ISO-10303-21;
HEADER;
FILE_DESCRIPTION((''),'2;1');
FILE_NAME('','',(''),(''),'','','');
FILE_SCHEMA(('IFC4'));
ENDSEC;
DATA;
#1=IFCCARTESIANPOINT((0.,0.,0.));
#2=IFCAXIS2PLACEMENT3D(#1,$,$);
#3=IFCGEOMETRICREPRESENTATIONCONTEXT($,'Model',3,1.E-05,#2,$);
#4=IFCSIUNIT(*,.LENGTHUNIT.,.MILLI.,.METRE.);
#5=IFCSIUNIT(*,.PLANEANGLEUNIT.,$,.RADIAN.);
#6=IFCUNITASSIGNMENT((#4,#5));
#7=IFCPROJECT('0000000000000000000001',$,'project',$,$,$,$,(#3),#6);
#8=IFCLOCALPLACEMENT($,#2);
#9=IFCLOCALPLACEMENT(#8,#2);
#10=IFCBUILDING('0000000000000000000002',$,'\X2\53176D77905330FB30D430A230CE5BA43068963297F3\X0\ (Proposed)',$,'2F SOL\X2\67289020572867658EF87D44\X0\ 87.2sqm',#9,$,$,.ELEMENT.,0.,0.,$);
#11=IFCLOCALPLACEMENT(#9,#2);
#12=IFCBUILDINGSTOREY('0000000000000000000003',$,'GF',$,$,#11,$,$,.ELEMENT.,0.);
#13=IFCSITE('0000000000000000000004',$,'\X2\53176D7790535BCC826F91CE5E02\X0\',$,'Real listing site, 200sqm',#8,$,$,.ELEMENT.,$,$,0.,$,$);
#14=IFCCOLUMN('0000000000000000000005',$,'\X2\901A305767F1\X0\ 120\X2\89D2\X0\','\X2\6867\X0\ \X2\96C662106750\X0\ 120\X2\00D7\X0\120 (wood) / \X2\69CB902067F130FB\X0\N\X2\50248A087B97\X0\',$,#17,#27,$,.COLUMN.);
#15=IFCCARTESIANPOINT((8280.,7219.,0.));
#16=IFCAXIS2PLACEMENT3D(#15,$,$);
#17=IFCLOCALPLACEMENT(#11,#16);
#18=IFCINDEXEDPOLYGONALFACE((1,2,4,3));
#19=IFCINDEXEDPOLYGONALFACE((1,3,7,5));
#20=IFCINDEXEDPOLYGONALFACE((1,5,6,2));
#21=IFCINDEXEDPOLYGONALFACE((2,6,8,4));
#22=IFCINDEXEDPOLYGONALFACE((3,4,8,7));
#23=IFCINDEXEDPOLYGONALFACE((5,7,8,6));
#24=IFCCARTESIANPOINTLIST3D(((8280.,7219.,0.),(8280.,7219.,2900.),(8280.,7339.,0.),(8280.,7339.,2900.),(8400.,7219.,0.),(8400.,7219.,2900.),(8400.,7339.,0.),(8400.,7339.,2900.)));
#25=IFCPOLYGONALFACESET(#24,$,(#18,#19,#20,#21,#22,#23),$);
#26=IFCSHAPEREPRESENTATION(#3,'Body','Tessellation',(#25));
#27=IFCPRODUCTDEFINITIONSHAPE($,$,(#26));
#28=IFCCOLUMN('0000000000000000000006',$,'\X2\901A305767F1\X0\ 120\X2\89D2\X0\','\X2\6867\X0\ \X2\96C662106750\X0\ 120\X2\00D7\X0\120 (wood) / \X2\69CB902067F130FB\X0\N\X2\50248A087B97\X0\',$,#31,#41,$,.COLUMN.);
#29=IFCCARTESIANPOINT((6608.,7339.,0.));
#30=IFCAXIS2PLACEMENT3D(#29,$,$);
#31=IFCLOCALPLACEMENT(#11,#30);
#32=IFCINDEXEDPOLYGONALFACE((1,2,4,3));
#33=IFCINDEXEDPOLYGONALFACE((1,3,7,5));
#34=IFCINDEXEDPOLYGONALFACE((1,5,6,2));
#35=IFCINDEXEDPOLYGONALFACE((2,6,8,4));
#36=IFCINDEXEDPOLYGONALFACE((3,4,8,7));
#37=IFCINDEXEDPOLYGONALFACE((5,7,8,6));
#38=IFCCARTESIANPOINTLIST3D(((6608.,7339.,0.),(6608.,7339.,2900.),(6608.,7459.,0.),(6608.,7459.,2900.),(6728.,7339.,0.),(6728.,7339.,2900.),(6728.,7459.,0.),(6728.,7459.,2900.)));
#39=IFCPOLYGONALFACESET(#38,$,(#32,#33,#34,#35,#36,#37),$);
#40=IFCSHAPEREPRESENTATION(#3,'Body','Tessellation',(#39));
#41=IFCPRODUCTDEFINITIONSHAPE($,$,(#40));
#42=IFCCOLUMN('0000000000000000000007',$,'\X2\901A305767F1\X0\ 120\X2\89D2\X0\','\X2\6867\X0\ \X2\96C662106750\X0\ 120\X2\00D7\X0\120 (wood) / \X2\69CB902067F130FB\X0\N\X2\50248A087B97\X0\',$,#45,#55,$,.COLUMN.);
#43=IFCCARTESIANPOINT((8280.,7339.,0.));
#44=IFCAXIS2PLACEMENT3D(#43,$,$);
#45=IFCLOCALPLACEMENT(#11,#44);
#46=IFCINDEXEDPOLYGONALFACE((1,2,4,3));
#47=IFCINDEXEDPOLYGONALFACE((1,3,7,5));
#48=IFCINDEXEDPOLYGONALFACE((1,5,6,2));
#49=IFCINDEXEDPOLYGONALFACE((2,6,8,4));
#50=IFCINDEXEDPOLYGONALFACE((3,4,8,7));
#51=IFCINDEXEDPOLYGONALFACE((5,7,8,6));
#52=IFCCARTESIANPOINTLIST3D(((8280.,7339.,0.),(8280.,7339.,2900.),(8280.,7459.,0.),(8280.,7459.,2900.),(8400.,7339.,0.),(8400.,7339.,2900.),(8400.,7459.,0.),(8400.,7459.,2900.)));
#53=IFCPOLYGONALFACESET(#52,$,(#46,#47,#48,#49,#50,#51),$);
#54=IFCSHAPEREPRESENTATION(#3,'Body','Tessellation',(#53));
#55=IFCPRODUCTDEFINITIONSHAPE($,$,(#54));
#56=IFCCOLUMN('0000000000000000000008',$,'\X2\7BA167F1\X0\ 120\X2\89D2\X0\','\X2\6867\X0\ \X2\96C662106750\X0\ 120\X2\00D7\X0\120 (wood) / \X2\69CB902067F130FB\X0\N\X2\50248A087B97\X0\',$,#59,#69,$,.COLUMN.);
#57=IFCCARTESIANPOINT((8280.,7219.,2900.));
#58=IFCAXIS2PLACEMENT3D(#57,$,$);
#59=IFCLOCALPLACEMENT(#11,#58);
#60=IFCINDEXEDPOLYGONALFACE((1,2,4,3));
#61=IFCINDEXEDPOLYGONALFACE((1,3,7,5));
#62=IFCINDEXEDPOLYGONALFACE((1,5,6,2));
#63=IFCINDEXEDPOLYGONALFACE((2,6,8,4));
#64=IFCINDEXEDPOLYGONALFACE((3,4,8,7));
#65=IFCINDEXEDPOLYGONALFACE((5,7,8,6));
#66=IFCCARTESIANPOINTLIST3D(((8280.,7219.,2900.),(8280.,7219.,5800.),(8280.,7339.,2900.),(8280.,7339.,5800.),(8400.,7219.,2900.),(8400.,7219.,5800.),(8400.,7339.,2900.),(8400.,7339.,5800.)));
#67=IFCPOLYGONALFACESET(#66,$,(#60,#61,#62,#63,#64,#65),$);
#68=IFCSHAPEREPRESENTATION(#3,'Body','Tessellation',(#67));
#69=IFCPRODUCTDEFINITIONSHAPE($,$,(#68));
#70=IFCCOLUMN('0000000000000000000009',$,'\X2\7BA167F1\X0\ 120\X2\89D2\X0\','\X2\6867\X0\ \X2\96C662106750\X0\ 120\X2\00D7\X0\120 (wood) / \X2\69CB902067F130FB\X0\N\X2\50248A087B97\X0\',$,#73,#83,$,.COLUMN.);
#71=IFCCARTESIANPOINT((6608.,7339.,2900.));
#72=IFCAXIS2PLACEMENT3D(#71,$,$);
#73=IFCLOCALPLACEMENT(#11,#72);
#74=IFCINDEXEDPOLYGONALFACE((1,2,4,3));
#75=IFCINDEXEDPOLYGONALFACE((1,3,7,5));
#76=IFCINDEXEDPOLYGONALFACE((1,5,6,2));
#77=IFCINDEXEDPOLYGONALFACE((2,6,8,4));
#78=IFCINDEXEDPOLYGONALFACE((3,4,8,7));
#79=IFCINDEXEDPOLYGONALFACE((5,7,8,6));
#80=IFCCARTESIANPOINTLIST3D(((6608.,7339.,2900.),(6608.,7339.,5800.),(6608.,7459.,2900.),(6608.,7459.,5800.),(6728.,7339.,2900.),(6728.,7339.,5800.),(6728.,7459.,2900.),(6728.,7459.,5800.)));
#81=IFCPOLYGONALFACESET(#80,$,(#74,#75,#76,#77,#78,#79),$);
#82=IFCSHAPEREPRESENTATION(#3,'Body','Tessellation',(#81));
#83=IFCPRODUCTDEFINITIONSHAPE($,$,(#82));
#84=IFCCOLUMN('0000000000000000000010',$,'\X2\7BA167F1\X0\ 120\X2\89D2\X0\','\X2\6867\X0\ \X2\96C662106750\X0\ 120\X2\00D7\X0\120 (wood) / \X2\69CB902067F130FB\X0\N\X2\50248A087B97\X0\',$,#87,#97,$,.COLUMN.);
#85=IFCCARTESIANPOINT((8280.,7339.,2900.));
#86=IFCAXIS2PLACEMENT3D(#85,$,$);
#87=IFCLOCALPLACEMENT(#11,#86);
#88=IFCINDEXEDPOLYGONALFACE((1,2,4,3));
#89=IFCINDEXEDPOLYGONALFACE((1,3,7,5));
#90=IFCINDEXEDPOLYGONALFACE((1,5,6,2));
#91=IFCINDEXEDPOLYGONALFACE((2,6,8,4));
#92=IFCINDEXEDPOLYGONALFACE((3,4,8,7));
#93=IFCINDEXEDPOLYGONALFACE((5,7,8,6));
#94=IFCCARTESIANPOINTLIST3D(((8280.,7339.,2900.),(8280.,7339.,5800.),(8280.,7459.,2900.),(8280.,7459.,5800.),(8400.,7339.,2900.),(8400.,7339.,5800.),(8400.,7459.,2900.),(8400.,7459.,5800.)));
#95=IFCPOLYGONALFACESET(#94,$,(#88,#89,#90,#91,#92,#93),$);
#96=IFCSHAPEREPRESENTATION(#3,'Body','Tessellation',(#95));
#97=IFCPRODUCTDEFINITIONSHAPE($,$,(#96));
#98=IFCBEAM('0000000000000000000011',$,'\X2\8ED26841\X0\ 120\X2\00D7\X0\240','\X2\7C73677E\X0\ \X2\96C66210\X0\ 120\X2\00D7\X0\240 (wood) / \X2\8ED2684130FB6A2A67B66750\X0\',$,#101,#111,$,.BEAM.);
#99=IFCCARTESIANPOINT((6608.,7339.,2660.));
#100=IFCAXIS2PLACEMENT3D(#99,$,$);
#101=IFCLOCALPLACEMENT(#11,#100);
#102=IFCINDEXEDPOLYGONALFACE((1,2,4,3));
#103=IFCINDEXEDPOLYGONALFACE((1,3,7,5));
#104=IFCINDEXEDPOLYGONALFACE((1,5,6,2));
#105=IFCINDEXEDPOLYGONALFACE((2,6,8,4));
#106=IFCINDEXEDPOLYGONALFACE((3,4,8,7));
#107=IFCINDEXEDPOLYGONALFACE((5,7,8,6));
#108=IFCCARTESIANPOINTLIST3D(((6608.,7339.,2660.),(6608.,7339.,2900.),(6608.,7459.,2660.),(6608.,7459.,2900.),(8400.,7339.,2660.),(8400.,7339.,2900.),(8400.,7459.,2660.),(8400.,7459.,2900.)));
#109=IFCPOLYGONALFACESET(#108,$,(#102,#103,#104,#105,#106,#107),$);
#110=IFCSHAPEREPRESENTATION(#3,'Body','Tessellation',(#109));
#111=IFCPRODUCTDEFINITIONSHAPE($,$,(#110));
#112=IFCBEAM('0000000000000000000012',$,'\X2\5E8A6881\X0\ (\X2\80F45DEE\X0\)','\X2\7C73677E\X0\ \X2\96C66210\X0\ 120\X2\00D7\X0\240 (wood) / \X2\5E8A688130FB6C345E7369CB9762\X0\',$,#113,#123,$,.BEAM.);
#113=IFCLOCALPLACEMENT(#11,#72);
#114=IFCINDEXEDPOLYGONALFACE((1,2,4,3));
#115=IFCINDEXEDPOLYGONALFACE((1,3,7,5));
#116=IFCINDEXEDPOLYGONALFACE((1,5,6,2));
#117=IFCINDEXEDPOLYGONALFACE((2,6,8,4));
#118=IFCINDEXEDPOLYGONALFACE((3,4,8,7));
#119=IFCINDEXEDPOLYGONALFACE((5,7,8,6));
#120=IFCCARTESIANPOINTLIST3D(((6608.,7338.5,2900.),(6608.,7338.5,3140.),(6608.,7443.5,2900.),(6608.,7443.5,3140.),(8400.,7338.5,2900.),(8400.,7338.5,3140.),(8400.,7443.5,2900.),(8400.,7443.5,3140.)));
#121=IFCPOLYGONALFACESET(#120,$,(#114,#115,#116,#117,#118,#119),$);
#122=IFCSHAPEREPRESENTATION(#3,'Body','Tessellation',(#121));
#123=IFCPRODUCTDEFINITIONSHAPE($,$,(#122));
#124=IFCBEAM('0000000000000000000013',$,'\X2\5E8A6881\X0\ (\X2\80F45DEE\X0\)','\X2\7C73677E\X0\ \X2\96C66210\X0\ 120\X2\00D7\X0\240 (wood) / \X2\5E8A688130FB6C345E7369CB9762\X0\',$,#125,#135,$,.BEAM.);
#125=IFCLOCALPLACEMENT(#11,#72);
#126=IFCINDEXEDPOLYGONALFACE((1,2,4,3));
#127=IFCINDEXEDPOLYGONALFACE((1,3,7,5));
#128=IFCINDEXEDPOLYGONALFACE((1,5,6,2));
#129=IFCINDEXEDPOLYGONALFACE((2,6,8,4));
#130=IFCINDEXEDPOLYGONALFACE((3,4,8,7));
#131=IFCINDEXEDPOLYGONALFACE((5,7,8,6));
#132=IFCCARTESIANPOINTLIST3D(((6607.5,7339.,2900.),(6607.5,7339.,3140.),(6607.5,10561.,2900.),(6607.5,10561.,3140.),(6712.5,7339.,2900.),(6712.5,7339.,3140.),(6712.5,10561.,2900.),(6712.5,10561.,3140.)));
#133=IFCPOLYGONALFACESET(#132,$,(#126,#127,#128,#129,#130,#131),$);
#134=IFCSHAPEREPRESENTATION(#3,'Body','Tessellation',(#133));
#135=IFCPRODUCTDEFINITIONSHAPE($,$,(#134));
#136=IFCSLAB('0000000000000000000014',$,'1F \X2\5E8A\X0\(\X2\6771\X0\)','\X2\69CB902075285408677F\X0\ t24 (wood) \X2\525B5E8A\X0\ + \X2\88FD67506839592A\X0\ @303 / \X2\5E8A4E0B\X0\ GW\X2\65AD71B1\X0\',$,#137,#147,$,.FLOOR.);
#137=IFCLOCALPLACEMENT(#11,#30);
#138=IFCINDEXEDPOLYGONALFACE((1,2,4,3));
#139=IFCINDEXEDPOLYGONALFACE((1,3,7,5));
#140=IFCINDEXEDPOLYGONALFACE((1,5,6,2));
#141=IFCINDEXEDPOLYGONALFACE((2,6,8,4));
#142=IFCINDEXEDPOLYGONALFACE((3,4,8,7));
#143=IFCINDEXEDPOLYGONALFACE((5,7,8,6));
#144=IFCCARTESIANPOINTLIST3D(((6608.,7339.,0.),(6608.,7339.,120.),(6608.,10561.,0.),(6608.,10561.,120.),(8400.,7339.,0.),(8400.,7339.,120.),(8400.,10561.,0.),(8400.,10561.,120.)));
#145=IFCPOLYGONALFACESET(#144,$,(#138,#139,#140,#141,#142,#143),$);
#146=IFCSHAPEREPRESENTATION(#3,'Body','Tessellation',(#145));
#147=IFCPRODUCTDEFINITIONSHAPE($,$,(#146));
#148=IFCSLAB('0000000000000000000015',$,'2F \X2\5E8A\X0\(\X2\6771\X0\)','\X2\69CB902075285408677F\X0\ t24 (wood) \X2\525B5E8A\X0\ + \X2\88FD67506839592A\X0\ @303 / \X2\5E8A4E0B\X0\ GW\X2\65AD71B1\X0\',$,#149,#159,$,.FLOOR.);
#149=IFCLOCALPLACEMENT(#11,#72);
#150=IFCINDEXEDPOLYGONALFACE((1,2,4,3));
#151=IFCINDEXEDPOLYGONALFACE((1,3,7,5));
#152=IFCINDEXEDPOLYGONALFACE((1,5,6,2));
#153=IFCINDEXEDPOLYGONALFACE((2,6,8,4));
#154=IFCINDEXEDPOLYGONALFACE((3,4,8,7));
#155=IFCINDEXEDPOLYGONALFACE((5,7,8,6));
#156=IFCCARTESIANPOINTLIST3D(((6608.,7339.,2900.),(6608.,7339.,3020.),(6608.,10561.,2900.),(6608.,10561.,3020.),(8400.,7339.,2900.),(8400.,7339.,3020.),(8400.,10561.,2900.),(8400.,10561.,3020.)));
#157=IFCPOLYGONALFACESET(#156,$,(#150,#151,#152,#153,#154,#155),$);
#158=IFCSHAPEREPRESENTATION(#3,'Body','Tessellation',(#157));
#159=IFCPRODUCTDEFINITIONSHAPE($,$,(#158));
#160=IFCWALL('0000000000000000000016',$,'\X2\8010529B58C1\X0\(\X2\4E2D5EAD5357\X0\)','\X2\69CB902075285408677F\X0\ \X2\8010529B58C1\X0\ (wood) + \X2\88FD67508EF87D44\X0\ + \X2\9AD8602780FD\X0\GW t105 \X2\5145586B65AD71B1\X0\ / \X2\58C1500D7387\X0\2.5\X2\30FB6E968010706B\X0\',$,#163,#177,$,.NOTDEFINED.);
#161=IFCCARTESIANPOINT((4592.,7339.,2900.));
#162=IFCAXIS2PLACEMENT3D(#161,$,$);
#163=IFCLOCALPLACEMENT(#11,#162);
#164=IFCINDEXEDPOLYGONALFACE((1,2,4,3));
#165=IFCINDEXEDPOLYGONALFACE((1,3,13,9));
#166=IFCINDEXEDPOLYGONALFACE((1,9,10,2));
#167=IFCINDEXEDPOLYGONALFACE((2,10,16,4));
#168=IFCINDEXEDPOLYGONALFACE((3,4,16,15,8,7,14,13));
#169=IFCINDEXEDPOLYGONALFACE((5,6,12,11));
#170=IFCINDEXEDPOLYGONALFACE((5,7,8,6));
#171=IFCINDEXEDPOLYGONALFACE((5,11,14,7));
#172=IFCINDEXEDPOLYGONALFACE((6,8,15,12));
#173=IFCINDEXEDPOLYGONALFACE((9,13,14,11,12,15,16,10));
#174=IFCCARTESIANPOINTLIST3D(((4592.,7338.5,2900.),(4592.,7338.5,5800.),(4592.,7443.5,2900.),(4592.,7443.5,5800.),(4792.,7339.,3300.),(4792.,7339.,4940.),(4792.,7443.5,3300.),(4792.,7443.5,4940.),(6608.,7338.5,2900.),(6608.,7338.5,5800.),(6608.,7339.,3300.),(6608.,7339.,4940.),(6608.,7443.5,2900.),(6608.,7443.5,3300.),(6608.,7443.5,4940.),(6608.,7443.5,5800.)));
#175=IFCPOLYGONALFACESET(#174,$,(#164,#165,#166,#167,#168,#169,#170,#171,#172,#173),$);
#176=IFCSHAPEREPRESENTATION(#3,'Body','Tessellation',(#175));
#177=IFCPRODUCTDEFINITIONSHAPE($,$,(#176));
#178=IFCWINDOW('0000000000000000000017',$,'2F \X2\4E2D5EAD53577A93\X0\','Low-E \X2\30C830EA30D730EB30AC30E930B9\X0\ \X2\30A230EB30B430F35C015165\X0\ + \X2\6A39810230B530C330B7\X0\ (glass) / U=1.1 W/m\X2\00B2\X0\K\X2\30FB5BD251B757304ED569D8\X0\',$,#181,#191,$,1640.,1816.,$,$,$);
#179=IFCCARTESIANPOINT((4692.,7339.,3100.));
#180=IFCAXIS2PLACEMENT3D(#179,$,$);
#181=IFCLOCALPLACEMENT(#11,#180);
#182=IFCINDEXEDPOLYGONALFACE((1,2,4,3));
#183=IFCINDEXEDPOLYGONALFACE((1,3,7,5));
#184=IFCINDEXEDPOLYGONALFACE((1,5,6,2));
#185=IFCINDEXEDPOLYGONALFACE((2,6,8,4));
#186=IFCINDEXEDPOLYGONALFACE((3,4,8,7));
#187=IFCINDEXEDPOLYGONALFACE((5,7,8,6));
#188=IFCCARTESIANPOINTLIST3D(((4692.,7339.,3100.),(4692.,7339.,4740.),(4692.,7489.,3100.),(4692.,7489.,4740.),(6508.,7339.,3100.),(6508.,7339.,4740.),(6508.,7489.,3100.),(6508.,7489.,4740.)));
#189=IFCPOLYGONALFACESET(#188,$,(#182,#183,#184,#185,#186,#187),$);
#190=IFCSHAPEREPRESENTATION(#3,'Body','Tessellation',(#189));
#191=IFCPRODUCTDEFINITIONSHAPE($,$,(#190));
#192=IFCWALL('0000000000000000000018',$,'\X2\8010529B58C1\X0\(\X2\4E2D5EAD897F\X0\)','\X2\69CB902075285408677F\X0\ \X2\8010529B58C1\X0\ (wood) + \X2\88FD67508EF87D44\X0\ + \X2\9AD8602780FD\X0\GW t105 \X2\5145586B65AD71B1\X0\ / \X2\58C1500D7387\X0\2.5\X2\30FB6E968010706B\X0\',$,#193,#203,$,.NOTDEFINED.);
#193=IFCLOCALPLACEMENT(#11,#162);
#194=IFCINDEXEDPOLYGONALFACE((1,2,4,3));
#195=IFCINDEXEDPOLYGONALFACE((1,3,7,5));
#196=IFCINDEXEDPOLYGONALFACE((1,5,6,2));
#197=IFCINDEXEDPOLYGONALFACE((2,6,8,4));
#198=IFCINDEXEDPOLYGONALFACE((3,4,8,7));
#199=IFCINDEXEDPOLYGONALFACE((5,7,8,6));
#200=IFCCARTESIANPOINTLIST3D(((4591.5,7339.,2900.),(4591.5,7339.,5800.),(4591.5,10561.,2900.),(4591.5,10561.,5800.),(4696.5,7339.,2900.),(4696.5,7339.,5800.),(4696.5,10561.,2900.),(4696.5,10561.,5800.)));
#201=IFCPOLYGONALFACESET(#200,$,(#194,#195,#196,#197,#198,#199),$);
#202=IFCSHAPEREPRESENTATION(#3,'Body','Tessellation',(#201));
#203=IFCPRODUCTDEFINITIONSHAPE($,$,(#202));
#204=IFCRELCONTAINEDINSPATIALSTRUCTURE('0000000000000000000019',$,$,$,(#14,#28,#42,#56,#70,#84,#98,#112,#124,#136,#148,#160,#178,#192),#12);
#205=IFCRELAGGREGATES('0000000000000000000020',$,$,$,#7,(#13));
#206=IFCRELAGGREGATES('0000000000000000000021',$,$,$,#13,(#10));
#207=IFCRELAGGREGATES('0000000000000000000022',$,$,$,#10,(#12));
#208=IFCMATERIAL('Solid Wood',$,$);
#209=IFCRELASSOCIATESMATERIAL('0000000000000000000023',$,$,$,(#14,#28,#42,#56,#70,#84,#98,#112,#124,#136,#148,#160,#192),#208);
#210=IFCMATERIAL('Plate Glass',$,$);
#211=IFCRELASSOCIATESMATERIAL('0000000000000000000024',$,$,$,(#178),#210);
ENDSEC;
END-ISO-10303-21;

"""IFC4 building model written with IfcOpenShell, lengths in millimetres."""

from ifc_helpers import new_model, si_unit, frame, frame_2d, origin, place, context, project, spatial, rectangle, extrude, material, element, fill, save


model = new_model("IFC4")

# Units and contexts
model_context = context("Model", 3, precision=1e-05, world=origin())
ifc_project = project(units=[si_unit("LENGTHUNIT", "METRE", prefix="MILLI"), si_unit("PLANEANGLEUNIT", "RADIAN")], contexts=[model_context])

# Site, building, storey
site_placement = place(None, origin())
site = spatial("IfcSite", under=ifc_project, at=site_placement, Name="北海道富良野市", ObjectType="Real listing site, 200sqm", CompositionType="ELEMENT", RefElevation=0.0)
building_placement = place(site_placement, origin())
building = spatial("IfcBuilding", under=site, at=building_placement, Name="北海道・ピアノ室と防音 (Proposed)", ObjectType="2F SOL木造在来軸組 87.2sqm", CompositionType="ELEMENT", ElevationOfRefHeight=0.0, ElevationOfTerrain=0.0)
storey_placement = place(building_placement, origin())
storey = spatial("IfcBuildingStorey", under=building, at=storey_placement, Name="GF", CompositionType="ELEMENT", Elevation=0.0)

# Columns
ifc_material_1 = material(Name="Solid Wood")
column_1_placement = place(storey_placement, frame((8280.0, 7219.0, 0.0)))
element("IfcColumn", 1, at=column_1_placement, inside=storey, material=ifc_material_1, Name="通し柱 120角", Description="桧 集成材 120×120 (wood) / 構造柱・N値計算", PredefinedType="COLUMN", context=model_context, shape_type="SweptSolid", body=[
    extrude(rectangle(XDim=120.0, YDim=120.0, at=frame_2d((60.0, 60.0))), frame((8280.0, 7219.0, 0.0)), (0.0, 0.0, 1.0), 2900.0),
])
column_2_placement = place(storey_placement, frame((6608.0, 7339.0, 0.0)))
element("IfcColumn", 2, at=column_2_placement, inside=storey, material=ifc_material_1, Name="通し柱 120角", Description="桧 集成材 120×120 (wood) / 構造柱・N値計算", PredefinedType="COLUMN", context=model_context, shape_type="SweptSolid", body=[
    extrude(rectangle(XDim=120.0, YDim=120.0, at=frame_2d((60.0, 60.0))), frame((6608.0, 7339.0, 0.0)), (0.0, 0.0, 1.0), 2900.0),
])
column_3_placement = place(storey_placement, frame((8280.0, 7339.0, 0.0)))
element("IfcColumn", 3, at=column_3_placement, inside=storey, material=ifc_material_1, Name="通し柱 120角", Description="桧 集成材 120×120 (wood) / 構造柱・N値計算", PredefinedType="COLUMN", context=model_context, shape_type="SweptSolid", body=[
    extrude(rectangle(XDim=120.0, YDim=120.0, at=frame_2d((60.0, 60.0))), frame((8280.0, 7339.0, 0.0)), (0.0, 0.0, 1.0), 2900.0),
])
column_4_placement = place(storey_placement, frame((8280.0, 7219.0, 2900.0)))
element("IfcColumn", 4, at=column_4_placement, inside=storey, material=ifc_material_1, Name="管柱 120角", Description="桧 集成材 120×120 (wood) / 構造柱・N値計算", PredefinedType="COLUMN", context=model_context, shape_type="SweptSolid", body=[
    extrude(rectangle(XDim=120.0, YDim=120.0, at=frame_2d((60.0, 60.0))), frame((8280.0, 7219.0, 2900.0)), (0.0, 0.0, 1.0), 2900.0),
])
column_5_placement = place(storey_placement, frame((6608.0, 7339.0, 2900.0)))
element("IfcColumn", 5, at=column_5_placement, inside=storey, material=ifc_material_1, Name="管柱 120角", Description="桧 集成材 120×120 (wood) / 構造柱・N値計算", PredefinedType="COLUMN", context=model_context, shape_type="SweptSolid", body=[
    extrude(rectangle(XDim=120.0, YDim=120.0, at=frame_2d((60.0, 60.0))), frame((6608.0, 7339.0, 2900.0)), (0.0, 0.0, 1.0), 2900.0),
])
column_6_placement = place(storey_placement, frame((8280.0, 7339.0, 2900.0)))
element("IfcColumn", 6, at=column_6_placement, inside=storey, material=ifc_material_1, Name="管柱 120角", Description="桧 集成材 120×120 (wood) / 構造柱・N値計算", PredefinedType="COLUMN", context=model_context, shape_type="SweptSolid", body=[
    extrude(rectangle(XDim=120.0, YDim=120.0, at=frame_2d((60.0, 60.0))), frame((8280.0, 7339.0, 2900.0)), (0.0, 0.0, 1.0), 2900.0),
])

# Beams
beam_1_placement = place(storey_placement, frame((6608.0, 7339.0, 2660.0)))
element("IfcBeam", 7, at=beam_1_placement, inside=storey, material=ifc_material_1, Name="軒桁 120×240", Description="米松 集成 120×240 (wood) / 軒桁・横架材", PredefinedType="BEAM", context=model_context, shape_type="SweptSolid", body=[
    extrude(rectangle(XDim=1792.0, YDim=120.0, at=frame_2d((896.0, 60.0))), frame((6608.0, 7339.0, 2660.0)), (0.0, 0.0, 1.0), 240.0),
])
beam_2_placement = place(storey_placement, frame((6608.0, 7339.0, 2900.0)))
element("IfcBeam", 8, at=beam_2_placement, inside=storey, material=ifc_material_1, Name="床梁 (胴差)", Description="米松 集成 120×240 (wood) / 床梁・水平構面", PredefinedType="BEAM", context=model_context, shape_type="SweptSolid", body=[
    extrude(rectangle(XDim=1792.0, YDim=105.0, at=frame_2d((896.0, 52.0))), frame((6608.0, 7339.0, 2900.0)), (0.0, 0.0, 1.0), 240.0),
])
beam_3_placement = place(storey_placement, frame((6608.0, 7339.0, 2900.0)))
element("IfcBeam", 9, at=beam_3_placement, inside=storey, material=ifc_material_1, Name="床梁 (胴差)", Description="米松 集成 120×240 (wood) / 床梁・水平構面", PredefinedType="BEAM", context=model_context, shape_type="SweptSolid", body=[
    extrude(rectangle(XDim=105.0, YDim=3222.0, at=frame_2d((52.0, 1611.0))), frame((6608.0, 7339.0, 2900.0)), (0.0, 0.0, 1.0), 240.0),
])

# Slabs
slab_1_placement = place(storey_placement, frame((6608.0, 7339.0, 0.0)))
element("IfcSlab", 10, at=slab_1_placement, inside=storey, material=ifc_material_1, Name="1F 床(東)", Description="構造用合板 t24 (wood) 剛床 + 製材根太 @303 / 床下 GW断熱", PredefinedType="FLOOR", context=model_context, shape_type="SweptSolid", body=[
    extrude(rectangle(XDim=1792.0, YDim=3222.0, at=frame_2d((896.0, 1611.0))), frame((6608.0, 7339.0, 0.0)), (0.0, 0.0, 1.0), 120.0),
])
slab_2_placement = place(storey_placement, frame((6608.0, 7339.0, 2900.0)))
element("IfcSlab", 11, at=slab_2_placement, inside=storey, material=ifc_material_1, Name="2F 床(東)", Description="構造用合板 t24 (wood) 剛床 + 製材根太 @303 / 床下 GW断熱", PredefinedType="FLOOR", context=model_context, shape_type="SweptSolid", body=[
    extrude(rectangle(XDim=1792.0, YDim=3222.0, at=frame_2d((896.0, 1611.0))), frame((6608.0, 7339.0, 2900.0)), (0.0, 0.0, 1.0), 120.0),
])

# Wall, opening, window
wall_1_placement = place(storey_placement, frame((4592.0, 7339.0, 2900.0)))
wall_1 = element("IfcWall", 12, at=wall_1_placement, inside=storey, material=ifc_material_1, Name="耐力壁(中庭南)", Description="構造用合板 耐力壁 (wood) + 製材軸組 + 高性能GW t105 充填断熱 / 壁倍率2.5・準耐火", PredefinedType="NOTDEFINED", context=model_context, shape_type="SweptSolid", body=[
    extrude(rectangle(XDim=2016.0, YDim=105.0, at=frame_2d((1008.0, 52.0))), frame((4592.0, 7339.0, 2900.0)), (0.0, 0.0, 1.0), 2900.0),
])
opening_placement = place(storey_placement, frame((4692.0, 7339.0, 3100.0)))
opening = element("IfcOpeningElement", 13, at=opening_placement, cuts=wall_1, PredefinedType="NOTDEFINED", context=model_context, shape_type="SweptSolid", body=[
    extrude(rectangle(XDim=1816.0, YDim=150.0, at=frame_2d((908.0, 75.0))), frame((4692.0, 7339.0, 3100.0)), (0.0, 0.0, 1.0), 1640.0),
])
ifc_material_2 = material(Name="Plate Glass")
window_1_placement = place(storey_placement, frame((4692.0, 7339.0, 3100.0)))
window_1 = element("IfcWindow", 14, at=window_1_placement, inside=storey, material=ifc_material_2, Name="2F 中庭南窓", Description="Low-E トリプルガラス アルゴン封入 + 樹脂サッシ (glass) / U=1.1 W/m²K・寒冷地仕様", OverallHeight=1640.0, OverallWidth=1816.0, context=model_context, shape_type="SweptSolid", body=[
    extrude(rectangle(XDim=1816.0, YDim=150.0, at=frame_2d((908.0, 75.0))), frame((4692.0, 7339.0, 3100.0)), (0.0, 0.0, 1.0), 1640.0),
])
fill(opening, window_1)

# Wall
wall_2_placement = place(storey_placement, frame((4592.0, 7339.0, 2900.0)))
element("IfcWall", 15, at=wall_2_placement, inside=storey, material=ifc_material_1, Name="耐力壁(中庭西)", Description="構造用合板 耐力壁 (wood) + 製材軸組 + 高性能GW t105 充填断熱 / 壁倍率2.5・準耐火", PredefinedType="NOTDEFINED", context=model_context, shape_type="SweptSolid", body=[
    extrude(rectangle(XDim=105.0, YDim=3222.0, at=frame_2d((52.0, 1611.0))), frame((4592.0, 7339.0, 2900.0)), (0.0, 0.0, 1.0), 2900.0),
])

save(model, "model.ifc")
